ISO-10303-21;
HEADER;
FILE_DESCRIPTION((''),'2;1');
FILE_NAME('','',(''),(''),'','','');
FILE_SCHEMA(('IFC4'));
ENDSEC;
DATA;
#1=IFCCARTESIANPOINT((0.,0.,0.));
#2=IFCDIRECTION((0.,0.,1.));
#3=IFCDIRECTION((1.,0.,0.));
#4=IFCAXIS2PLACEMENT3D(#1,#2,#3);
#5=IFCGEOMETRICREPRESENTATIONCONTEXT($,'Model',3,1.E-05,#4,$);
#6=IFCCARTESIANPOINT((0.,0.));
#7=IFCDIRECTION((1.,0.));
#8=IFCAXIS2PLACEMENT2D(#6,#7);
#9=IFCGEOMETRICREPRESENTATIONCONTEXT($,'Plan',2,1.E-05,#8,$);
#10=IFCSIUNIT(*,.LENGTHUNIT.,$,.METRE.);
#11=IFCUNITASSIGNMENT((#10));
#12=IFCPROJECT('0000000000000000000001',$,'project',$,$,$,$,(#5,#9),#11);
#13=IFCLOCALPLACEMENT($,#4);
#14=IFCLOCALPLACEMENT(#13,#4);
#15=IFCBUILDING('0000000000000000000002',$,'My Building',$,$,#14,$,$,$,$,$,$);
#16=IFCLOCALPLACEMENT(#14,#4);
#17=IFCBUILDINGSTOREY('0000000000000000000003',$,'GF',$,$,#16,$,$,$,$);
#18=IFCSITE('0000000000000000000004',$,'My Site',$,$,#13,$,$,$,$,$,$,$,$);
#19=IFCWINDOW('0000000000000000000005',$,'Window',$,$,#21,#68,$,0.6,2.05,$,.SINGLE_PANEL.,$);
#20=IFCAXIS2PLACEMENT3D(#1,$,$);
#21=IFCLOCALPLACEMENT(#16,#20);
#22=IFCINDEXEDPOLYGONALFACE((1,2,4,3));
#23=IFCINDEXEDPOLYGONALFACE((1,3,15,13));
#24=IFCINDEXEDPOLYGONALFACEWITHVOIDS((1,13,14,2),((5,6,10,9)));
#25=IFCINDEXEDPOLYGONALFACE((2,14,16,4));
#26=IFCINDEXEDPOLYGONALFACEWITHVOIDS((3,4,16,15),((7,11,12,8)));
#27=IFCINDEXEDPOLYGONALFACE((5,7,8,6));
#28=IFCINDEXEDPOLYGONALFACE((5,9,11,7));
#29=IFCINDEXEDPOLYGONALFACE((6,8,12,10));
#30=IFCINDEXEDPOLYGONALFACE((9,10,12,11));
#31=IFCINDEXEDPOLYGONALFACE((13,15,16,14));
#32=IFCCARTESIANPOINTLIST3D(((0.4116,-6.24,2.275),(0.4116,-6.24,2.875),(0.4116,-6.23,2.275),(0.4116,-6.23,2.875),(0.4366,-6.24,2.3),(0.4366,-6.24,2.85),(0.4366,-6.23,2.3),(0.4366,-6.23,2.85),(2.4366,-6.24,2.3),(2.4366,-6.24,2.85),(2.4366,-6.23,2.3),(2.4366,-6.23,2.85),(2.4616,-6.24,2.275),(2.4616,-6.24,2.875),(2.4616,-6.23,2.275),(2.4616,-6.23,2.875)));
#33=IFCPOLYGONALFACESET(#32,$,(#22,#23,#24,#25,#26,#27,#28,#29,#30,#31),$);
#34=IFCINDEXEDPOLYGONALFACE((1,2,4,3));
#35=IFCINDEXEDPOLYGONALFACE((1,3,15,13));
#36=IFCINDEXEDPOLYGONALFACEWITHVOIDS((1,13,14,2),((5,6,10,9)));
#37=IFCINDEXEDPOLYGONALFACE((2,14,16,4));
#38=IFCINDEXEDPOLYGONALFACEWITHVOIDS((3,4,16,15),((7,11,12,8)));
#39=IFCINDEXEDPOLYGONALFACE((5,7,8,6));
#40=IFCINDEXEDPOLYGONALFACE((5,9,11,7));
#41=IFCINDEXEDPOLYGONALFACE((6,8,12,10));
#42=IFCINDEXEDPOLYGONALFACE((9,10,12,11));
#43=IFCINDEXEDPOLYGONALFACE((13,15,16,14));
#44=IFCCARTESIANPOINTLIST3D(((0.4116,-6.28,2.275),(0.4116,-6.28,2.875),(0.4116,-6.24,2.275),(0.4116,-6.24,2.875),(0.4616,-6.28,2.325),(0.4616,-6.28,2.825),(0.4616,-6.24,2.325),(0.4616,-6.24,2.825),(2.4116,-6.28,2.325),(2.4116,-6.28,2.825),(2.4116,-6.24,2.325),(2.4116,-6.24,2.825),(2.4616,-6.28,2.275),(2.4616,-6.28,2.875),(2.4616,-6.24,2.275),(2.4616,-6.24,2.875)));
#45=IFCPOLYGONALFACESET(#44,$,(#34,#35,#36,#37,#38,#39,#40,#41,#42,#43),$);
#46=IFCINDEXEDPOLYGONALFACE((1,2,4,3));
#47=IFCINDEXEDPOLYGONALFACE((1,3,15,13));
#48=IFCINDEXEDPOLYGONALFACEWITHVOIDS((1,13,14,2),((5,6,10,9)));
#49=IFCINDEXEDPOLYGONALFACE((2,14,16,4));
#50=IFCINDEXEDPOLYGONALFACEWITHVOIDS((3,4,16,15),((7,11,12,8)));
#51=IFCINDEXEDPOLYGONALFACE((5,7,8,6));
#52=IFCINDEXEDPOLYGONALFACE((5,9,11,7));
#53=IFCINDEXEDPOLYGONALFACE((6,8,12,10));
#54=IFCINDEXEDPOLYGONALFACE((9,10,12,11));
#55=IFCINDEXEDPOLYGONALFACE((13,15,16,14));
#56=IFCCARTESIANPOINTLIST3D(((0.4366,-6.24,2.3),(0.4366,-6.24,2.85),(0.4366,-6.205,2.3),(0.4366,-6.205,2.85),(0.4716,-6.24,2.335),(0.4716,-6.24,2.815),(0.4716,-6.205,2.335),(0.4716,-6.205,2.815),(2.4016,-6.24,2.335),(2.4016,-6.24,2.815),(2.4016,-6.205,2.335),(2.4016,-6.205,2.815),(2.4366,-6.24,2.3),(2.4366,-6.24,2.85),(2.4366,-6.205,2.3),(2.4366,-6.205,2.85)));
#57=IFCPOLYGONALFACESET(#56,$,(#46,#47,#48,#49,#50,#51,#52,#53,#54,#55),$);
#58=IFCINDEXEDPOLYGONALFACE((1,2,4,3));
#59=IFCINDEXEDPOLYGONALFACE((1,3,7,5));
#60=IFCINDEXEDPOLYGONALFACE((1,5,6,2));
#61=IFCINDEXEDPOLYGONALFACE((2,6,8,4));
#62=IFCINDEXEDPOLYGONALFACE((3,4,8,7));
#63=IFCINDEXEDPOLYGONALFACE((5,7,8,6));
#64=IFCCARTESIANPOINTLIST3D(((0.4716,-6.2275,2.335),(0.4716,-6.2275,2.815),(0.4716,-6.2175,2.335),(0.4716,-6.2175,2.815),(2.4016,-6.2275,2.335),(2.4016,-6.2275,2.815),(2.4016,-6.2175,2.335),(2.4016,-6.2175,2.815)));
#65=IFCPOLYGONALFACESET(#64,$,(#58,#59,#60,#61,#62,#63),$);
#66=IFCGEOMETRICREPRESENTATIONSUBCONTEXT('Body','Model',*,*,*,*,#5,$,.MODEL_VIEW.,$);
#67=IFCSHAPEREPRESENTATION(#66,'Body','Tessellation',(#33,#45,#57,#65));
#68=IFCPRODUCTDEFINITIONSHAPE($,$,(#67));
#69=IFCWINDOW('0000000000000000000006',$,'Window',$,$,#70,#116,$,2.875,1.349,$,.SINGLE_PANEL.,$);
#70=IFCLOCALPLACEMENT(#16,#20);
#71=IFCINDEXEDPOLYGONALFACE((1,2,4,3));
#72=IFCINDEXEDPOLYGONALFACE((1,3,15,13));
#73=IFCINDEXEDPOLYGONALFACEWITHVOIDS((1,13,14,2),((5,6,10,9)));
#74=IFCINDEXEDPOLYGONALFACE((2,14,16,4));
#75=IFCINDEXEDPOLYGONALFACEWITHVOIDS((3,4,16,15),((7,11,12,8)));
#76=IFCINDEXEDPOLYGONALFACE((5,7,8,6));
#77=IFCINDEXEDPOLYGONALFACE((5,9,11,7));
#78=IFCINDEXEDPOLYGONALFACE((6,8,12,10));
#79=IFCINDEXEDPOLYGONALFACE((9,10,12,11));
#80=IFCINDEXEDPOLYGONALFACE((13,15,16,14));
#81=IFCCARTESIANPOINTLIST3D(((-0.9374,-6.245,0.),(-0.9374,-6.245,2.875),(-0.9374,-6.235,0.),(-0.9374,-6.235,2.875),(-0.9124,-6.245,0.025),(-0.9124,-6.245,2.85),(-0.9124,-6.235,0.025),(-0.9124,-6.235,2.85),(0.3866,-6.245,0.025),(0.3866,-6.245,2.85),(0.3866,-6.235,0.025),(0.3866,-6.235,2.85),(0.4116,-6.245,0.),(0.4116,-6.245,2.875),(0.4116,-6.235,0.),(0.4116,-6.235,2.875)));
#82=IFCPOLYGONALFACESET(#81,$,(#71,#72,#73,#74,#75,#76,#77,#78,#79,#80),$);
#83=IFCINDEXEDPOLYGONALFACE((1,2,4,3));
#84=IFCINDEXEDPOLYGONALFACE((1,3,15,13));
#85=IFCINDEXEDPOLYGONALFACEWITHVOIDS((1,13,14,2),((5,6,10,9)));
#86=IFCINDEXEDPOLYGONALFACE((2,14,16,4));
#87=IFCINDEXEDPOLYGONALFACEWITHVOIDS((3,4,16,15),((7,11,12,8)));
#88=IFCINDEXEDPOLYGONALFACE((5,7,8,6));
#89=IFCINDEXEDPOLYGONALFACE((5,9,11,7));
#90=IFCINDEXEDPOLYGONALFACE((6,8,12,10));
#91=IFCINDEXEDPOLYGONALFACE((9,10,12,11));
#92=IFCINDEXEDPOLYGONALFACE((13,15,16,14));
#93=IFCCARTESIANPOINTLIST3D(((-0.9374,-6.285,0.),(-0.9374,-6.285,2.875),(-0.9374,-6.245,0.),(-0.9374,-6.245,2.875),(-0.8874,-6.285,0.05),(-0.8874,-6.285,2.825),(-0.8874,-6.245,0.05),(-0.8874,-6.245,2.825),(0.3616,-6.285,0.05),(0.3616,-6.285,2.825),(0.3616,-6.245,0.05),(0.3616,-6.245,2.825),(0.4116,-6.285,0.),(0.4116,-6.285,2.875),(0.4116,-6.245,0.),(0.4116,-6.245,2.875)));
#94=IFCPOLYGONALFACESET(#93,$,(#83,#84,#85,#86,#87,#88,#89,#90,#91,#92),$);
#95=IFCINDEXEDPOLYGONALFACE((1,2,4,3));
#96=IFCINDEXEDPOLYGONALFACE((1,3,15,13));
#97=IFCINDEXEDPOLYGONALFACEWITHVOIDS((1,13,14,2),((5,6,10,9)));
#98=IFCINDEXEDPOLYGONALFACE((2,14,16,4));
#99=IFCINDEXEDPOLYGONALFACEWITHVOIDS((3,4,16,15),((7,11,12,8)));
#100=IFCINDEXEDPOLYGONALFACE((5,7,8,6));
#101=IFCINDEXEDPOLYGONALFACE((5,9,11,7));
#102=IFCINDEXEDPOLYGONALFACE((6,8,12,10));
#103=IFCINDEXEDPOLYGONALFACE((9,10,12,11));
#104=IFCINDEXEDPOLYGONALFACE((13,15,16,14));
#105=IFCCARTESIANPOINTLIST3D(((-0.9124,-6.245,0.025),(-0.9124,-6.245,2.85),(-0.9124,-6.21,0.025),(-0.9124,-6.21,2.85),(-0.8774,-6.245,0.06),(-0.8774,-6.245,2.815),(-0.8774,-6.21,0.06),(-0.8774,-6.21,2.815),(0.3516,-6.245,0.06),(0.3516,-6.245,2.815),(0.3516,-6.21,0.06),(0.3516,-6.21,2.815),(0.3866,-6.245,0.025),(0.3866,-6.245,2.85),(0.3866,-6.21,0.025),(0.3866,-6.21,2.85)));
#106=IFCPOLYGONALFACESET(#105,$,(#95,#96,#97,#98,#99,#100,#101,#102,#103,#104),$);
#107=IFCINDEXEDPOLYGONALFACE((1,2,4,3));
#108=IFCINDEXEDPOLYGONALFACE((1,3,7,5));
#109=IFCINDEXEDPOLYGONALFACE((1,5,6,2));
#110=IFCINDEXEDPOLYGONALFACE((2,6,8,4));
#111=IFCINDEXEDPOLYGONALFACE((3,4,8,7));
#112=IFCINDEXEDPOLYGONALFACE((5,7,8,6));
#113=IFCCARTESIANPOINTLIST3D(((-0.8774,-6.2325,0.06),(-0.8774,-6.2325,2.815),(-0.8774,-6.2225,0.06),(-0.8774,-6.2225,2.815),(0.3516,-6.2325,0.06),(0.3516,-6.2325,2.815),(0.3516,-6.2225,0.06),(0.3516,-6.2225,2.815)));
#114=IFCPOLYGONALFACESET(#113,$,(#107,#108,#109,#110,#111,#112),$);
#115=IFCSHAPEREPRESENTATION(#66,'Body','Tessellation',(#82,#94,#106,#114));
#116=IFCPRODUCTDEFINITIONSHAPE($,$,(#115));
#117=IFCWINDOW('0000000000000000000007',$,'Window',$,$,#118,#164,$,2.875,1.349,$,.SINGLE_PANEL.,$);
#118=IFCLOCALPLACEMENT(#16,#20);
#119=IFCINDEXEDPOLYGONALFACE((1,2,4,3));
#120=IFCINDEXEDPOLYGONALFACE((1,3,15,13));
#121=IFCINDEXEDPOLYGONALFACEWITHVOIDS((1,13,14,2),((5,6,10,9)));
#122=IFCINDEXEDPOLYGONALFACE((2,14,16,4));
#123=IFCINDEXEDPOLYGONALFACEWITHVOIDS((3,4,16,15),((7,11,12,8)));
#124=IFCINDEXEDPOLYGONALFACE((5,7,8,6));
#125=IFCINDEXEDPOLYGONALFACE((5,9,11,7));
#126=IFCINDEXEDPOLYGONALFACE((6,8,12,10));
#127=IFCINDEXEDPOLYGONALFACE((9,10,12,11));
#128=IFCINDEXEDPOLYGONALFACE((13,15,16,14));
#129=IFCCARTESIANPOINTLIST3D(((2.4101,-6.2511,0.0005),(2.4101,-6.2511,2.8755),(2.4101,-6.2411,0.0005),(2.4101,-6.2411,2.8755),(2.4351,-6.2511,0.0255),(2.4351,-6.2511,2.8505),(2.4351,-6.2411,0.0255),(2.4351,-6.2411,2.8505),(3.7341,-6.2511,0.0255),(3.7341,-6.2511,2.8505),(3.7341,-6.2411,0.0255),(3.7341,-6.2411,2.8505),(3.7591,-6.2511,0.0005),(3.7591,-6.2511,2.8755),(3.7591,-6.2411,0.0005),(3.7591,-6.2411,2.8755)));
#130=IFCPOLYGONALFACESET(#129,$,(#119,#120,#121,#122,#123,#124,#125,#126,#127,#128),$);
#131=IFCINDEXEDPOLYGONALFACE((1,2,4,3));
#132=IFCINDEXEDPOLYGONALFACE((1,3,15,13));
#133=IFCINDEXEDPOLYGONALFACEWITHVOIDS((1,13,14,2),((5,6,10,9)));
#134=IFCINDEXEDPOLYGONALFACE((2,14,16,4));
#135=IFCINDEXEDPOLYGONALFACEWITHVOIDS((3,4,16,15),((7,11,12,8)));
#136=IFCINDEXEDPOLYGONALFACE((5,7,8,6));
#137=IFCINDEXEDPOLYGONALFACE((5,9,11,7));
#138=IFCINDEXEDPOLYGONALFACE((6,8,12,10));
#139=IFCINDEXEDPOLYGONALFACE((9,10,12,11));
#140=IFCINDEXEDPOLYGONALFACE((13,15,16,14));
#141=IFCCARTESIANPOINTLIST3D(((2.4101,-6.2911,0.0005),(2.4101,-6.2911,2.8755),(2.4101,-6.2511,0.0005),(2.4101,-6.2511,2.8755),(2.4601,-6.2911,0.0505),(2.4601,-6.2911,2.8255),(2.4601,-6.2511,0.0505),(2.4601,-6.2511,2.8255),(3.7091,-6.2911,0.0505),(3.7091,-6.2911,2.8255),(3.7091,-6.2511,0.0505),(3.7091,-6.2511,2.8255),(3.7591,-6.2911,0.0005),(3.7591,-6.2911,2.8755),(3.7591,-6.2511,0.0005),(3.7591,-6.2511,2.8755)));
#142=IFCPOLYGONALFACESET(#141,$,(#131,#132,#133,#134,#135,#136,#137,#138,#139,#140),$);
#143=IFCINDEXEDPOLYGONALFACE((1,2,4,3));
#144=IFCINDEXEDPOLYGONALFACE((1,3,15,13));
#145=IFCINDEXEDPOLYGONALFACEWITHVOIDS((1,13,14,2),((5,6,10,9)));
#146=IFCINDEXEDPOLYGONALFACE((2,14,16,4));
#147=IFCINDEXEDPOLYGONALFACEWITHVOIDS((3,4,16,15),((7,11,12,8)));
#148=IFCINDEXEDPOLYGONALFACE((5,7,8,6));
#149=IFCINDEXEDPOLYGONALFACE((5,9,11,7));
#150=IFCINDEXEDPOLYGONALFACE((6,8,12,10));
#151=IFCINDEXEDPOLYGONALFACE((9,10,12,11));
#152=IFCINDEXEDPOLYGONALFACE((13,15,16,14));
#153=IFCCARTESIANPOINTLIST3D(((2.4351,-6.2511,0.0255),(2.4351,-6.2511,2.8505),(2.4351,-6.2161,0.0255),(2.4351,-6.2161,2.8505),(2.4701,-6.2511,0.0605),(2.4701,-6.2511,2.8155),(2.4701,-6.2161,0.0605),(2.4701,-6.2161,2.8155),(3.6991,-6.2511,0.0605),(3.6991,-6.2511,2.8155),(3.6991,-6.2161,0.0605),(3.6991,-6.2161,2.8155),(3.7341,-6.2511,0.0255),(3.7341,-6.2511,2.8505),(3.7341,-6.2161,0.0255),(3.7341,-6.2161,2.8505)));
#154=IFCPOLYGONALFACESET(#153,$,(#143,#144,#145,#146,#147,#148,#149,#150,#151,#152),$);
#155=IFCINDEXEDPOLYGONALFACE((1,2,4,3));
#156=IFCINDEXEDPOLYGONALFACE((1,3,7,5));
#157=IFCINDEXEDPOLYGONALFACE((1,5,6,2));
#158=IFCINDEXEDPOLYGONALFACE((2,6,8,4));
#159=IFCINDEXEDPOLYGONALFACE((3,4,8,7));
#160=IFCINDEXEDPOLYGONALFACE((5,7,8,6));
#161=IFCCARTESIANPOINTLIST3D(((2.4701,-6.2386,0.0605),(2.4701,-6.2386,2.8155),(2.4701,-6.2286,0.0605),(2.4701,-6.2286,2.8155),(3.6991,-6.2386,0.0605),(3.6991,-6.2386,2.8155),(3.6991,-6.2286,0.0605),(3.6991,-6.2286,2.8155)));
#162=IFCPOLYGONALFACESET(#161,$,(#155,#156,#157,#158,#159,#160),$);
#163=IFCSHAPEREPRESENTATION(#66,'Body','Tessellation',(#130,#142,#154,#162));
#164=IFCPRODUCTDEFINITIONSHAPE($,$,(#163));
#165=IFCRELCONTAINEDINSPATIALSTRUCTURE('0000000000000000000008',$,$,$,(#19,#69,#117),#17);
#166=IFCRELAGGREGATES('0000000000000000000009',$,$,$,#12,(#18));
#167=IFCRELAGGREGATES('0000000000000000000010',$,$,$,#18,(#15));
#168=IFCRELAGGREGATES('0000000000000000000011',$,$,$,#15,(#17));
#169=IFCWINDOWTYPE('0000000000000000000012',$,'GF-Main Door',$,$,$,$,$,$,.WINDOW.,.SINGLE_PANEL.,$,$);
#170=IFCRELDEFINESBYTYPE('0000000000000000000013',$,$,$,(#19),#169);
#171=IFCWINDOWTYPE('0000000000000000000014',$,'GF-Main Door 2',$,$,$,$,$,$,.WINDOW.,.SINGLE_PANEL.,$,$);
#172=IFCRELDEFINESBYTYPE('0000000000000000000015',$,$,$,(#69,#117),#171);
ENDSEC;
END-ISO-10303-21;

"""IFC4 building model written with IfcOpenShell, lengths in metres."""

from ifc_helpers import new_model, entity, si_unit, frame, origin_with_axes, origin_2d_with_axis, place, context, subcontext, project, spatial, line, indexed_curve, outline, extrude, shape, source, transform, mapped, type_object, type_shapes, element, save


model = new_model("IFC4")

# Units and contexts
model_context = context("Model", 3, precision=1e-05, world=origin_with_axes())
plan_context = context("Plan", 2, precision=1e-05, world=origin_2d_with_axis())
body_context_1 = subcontext(model_context, "Body", "Model", "MODEL_VIEW")
body_context_2 = subcontext(plan_context, "Body", "Plan", "PLAN_VIEW")
ifc_project = project(units=[si_unit("LENGTHUNIT", "METRE")], contexts=[model_context, plan_context])

# Site, building, storey
site_placement = place(None, origin_with_axes())
site = spatial("IfcSite", under=ifc_project, at=site_placement, Name="My Site")
building_placement = place(site_placement, origin_with_axes())
building = spatial("IfcBuilding", under=site, at=building_placement, Name="My Building")
storey_placement = place(building_placement, origin_with_axes())
storey = spatial("IfcBuildingStorey", under=building, at=storey_placement, Name="GF")

# Windows
window_type_1 = type_object("IfcWindowType", Name="GF-Main Door", PartitioningType="SINGLE_PANEL", PredefinedType="WINDOW")
shared_shape_1 = source(origin_with_axes(), body_context_1, "Body", "SweptSolid", [
    extrude(outline(indexed_curve([(0.0, 0.0), (2.05, 0.0), (2.05, 0.6), (0.0, 0.6)], segments=[line(1, 2, 3, 4, 1)]), holes=[indexed_curve([(0.025, 0.025), (2.025, 0.025), (2.025, 0.575), (0.025, 0.575)], segments=[line(1, 2, 3, 4, 1)])]), frame((0.0, 0.09, 0.0), z_axis=(0.0, -1.0, 0.0), x_axis=(1.0, 0.0, 0.0)), (0.0, 0.0, -1.0), 0.01),
    extrude(outline(indexed_curve([(0.0, 0.0), (2.05, 0.0), (2.05, 0.6), (0.0, 0.6)], segments=[line(1, 2, 3, 4, 1)]), holes=[indexed_curve([(0.05, 0.05), (2.0, 0.05), (2.0, 0.55), (0.05, 0.55)], segments=[line(1, 2, 3, 4, 1)])]), frame((0.0, 0.05, 0.0), z_axis=(0.0, -1.0, 0.0), x_axis=(1.0, 0.0, 0.0)), (0.0, 0.0, -1.0), 0.04),
    extrude(outline(indexed_curve([(0.0, 0.0), (2.0, 0.0), (2.0, 0.55), (0.0, 0.55)], segments=[line(1, 2, 3, 4, 1)]), holes=[indexed_curve([(0.035, 0.035), (1.965, 0.035), (1.965, 0.515), (0.035, 0.515)], segments=[line(1, 2, 3, 4, 1)])]), frame((0.025, 0.09, 0.025), z_axis=(0.0, -1.0, 0.0), x_axis=(1.0, 0.0, 0.0)), (0.0, 0.0, -1.0), 0.035),
    extrude(outline(indexed_curve([(0.035, 0.035), (1.965, 0.035), (1.965, 0.515), (0.035, 0.515)], segments=[line(1, 2, 3, 4, 1)])), frame((0.025, 0.1025, 0.025), z_axis=(0.0, -1.0, 0.0), x_axis=(1.0, 0.0, 0.0)), (0.0, 0.0, -1.0), 0.01),
])
shared_shape_2 = source(origin_with_axes(), body_context_2, "Body", "Curve2D", [
    entity("IfcIndexedPolyCurve", entity("IfcCartesianPointList2D", [[0.05, 0.05], [2.0, 0.05]])),
    entity("IfcIndexedPolyCurve", entity("IfcCartesianPointList2D", [[0.0, 0.1], [0.025, 0.1], [0.025, 0.09], [0.05, 0.09], [0.05, 0.05], [0.0, 0.05]]), [entity("IfcLineIndex", [1, 2, 3, 4, 5, 6, 1])]),
    entity("IfcIndexedPolyCurve", entity("IfcCartesianPointList2D", [[2.05, 0.1], [2.025, 0.1], [2.025, 0.09], [2.0, 0.09], [2.0, 0.05], [2.05, 0.05]]), [entity("IfcLineIndex", [1, 2, 3, 4, 5, 6, 1])]),
    entity("IfcIndexedPolyCurve", entity("IfcCartesianPointList2D", [[0.025, 0.09], [0.06, 0.09], [0.06, 0.125], [0.025, 0.125]]), [entity("IfcLineIndex", [1, 2, 3, 4, 1])]),
    entity("IfcIndexedPolyCurve", entity("IfcCartesianPointList2D", [[2.025, 0.09], [1.99, 0.09], [1.99, 0.125], [2.025, 0.125]]), [entity("IfcLineIndex", [1, 2, 3, 4, 1])]),
    entity("IfcIndexedPolyCurve", entity("IfcCartesianPointList2D", [[0.06, 0.09], [1.99, 0.09]])),
    entity("IfcIndexedPolyCurve", entity("IfcCartesianPointList2D", [[0.06, 0.125], [1.99, 0.125]])),
    entity("IfcIndexedPolyCurve", entity("IfcCartesianPointList2D", [[0.06, 0.1075], [1.99, 0.1075]])),
])
type_shapes(window_type_1, [shared_shape_1, shared_shape_2])
window_placement = place(storey_placement, frame((0.4116, -6.33, 2.275), z_axis=(0.0, 0.0, 1.0), x_axis=(1.0, 0.0, 0.0)))
element("IfcWindow", 1, at=window_placement, inside=storey, type_object=window_type_1, Name="Window", OverallHeight=0.6, OverallWidth=2.05, PartitioningType="SINGLE_PANEL", shapes=[
    shape(body_context_1, "Body", "MappedRepresentation", [mapped(shared_shape_1, transform((0.0, 0.0, 0.0), x_axis=(1.0, 0.0, 0.0), y_axis=(0.0, 1.0, 0.0), z_axis=(0.0, 0.0, 1.0), scale=1.0))]),
    shape(body_context_2, "Body", "MappedRepresentation", [mapped(shared_shape_2, transform((0.0, 0.0, 0.0), x_axis=(1.0, 0.0, 0.0), y_axis=(0.0, 1.0, 0.0), z_axis=(0.0, 0.0, 1.0), scale=1.0))]),
])
window_type_2 = type_object("IfcWindowType", Name="GF-Main Door 2", PartitioningType="SINGLE_PANEL", PredefinedType="WINDOW")
shared_shape_3 = source(origin_with_axes(), body_context_1, "Body", "SweptSolid", [
    extrude(outline(indexed_curve([(0.0, 0.0), (1.349, 0.0), (1.349, 2.875), (0.0, 2.875)], segments=[line(1, 2, 3, 4, 1)]), holes=[indexed_curve([(0.025, 0.025), (1.324, 0.025), (1.324, 2.85), (0.025, 2.85)], segments=[line(1, 2, 3, 4, 1)])]), frame((0.0, 0.09, 0.0), z_axis=(0.0, -1.0, 0.0), x_axis=(1.0, 0.0, 0.0)), (0.0, 0.0, -1.0), 0.01),
    extrude(outline(indexed_curve([(0.0, 0.0), (1.349, 0.0), (1.349, 2.875), (0.0, 2.875)], segments=[line(1, 2, 3, 4, 1)]), holes=[indexed_curve([(0.05, 0.05), (1.299, 0.05), (1.299, 2.825), (0.05, 2.825)], segments=[line(1, 2, 3, 4, 1)])]), frame((0.0, 0.05, 0.0), z_axis=(0.0, -1.0, 0.0), x_axis=(1.0, 0.0, 0.0)), (0.0, 0.0, -1.0), 0.04),
    extrude(outline(indexed_curve([(0.0, 0.0), (1.299, 0.0), (1.299, 2.825), (0.0, 2.825)], segments=[line(1, 2, 3, 4, 1)]), holes=[indexed_curve([(0.035, 0.035), (1.264, 0.035), (1.264, 2.79), (0.035, 2.79)], segments=[line(1, 2, 3, 4, 1)])]), frame((0.025, 0.09, 0.025), z_axis=(0.0, -1.0, 0.0), x_axis=(1.0, 0.0, 0.0)), (0.0, 0.0, -1.0), 0.035),
    extrude(outline(indexed_curve([(0.035, 0.035), (1.264, 0.035), (1.264, 2.79), (0.035, 2.79)], segments=[line(1, 2, 3, 4, 1)])), frame((0.025, 0.1025, 0.025), z_axis=(0.0, -1.0, 0.0), x_axis=(1.0, 0.0, 0.0)), (0.0, 0.0, -1.0), 0.01),
])
shared_shape_4 = source(origin_with_axes(), body_context_2, "Body", "Curve2D", [
    entity("IfcIndexedPolyCurve", entity("IfcCartesianPointList2D", [[0.05, 0.05], [1.299, 0.05]])),
    entity("IfcIndexedPolyCurve", entity("IfcCartesianPointList2D", [[0.0, 0.1], [0.025, 0.1], [0.025, 0.09], [0.05, 0.09], [0.05, 0.05], [0.0, 0.05]]), [entity("IfcLineIndex", [1, 2, 3, 4, 5, 6, 1])]),
    entity("IfcIndexedPolyCurve", entity("IfcCartesianPointList2D", [[1.349, 0.1], [1.324, 0.1], [1.324, 0.09], [1.299, 0.09], [1.299, 0.05], [1.349, 0.05]]), [entity("IfcLineIndex", [1, 2, 3, 4, 5, 6, 1])]),
    entity("IfcIndexedPolyCurve", entity("IfcCartesianPointList2D", [[0.025, 0.09], [0.06, 0.09], [0.06, 0.125], [0.025, 0.125]]), [entity("IfcLineIndex", [1, 2, 3, 4, 1])]),
    entity("IfcIndexedPolyCurve", entity("IfcCartesianPointList2D", [[1.324, 0.09], [1.289, 0.09], [1.289, 0.125], [1.324, 0.125]]), [entity("IfcLineIndex", [1, 2, 3, 4, 1])]),
    entity("IfcIndexedPolyCurve", entity("IfcCartesianPointList2D", [[0.06, 0.09], [1.289, 0.09]])),
    entity("IfcIndexedPolyCurve", entity("IfcCartesianPointList2D", [[0.06, 0.125], [1.289, 0.125]])),
    entity("IfcIndexedPolyCurve", entity("IfcCartesianPointList2D", [[0.06, 0.1075], [1.289, 0.1075]])),
])
type_shapes(window_type_2, [shared_shape_3, shared_shape_4])
for number, where, z_axis, x_axis, name in (
    (2, (-0.9374, -6.335, 0.0), (0.0, 0.0, 1.0), (1.0, 0.0, 0.0), "Window"),
    (3, (2.4101, -6.3411, 0.0005), (0.0, 0.0, 1.0), (1.0, 0.0, 0.0), "Window"),
):
    element("IfcWindow", number, at=place(storey_placement, frame(where, z_axis=z_axis, x_axis=x_axis)), inside=storey, type_object=window_type_2, Name=name, OverallHeight=2.875, OverallWidth=1.349, PartitioningType="SINGLE_PANEL", shapes=[
        shape(body_context_1, "Body", "MappedRepresentation", [mapped(shared_shape_3, transform((0.0, 0.0, 0.0), x_axis=(1.0, 0.0, 0.0), y_axis=(0.0, 1.0, 0.0), z_axis=(0.0, 0.0, 1.0), scale=1.0))]),
        shape(body_context_2, "Body", "MappedRepresentation", [mapped(shared_shape_4, transform((0.0, 0.0, 0.0), x_axis=(1.0, 0.0, 0.0), y_axis=(0.0, 1.0, 0.0), z_axis=(0.0, 0.0, 1.0), scale=1.0))]),
    ])

save(model, "model.ifc")
